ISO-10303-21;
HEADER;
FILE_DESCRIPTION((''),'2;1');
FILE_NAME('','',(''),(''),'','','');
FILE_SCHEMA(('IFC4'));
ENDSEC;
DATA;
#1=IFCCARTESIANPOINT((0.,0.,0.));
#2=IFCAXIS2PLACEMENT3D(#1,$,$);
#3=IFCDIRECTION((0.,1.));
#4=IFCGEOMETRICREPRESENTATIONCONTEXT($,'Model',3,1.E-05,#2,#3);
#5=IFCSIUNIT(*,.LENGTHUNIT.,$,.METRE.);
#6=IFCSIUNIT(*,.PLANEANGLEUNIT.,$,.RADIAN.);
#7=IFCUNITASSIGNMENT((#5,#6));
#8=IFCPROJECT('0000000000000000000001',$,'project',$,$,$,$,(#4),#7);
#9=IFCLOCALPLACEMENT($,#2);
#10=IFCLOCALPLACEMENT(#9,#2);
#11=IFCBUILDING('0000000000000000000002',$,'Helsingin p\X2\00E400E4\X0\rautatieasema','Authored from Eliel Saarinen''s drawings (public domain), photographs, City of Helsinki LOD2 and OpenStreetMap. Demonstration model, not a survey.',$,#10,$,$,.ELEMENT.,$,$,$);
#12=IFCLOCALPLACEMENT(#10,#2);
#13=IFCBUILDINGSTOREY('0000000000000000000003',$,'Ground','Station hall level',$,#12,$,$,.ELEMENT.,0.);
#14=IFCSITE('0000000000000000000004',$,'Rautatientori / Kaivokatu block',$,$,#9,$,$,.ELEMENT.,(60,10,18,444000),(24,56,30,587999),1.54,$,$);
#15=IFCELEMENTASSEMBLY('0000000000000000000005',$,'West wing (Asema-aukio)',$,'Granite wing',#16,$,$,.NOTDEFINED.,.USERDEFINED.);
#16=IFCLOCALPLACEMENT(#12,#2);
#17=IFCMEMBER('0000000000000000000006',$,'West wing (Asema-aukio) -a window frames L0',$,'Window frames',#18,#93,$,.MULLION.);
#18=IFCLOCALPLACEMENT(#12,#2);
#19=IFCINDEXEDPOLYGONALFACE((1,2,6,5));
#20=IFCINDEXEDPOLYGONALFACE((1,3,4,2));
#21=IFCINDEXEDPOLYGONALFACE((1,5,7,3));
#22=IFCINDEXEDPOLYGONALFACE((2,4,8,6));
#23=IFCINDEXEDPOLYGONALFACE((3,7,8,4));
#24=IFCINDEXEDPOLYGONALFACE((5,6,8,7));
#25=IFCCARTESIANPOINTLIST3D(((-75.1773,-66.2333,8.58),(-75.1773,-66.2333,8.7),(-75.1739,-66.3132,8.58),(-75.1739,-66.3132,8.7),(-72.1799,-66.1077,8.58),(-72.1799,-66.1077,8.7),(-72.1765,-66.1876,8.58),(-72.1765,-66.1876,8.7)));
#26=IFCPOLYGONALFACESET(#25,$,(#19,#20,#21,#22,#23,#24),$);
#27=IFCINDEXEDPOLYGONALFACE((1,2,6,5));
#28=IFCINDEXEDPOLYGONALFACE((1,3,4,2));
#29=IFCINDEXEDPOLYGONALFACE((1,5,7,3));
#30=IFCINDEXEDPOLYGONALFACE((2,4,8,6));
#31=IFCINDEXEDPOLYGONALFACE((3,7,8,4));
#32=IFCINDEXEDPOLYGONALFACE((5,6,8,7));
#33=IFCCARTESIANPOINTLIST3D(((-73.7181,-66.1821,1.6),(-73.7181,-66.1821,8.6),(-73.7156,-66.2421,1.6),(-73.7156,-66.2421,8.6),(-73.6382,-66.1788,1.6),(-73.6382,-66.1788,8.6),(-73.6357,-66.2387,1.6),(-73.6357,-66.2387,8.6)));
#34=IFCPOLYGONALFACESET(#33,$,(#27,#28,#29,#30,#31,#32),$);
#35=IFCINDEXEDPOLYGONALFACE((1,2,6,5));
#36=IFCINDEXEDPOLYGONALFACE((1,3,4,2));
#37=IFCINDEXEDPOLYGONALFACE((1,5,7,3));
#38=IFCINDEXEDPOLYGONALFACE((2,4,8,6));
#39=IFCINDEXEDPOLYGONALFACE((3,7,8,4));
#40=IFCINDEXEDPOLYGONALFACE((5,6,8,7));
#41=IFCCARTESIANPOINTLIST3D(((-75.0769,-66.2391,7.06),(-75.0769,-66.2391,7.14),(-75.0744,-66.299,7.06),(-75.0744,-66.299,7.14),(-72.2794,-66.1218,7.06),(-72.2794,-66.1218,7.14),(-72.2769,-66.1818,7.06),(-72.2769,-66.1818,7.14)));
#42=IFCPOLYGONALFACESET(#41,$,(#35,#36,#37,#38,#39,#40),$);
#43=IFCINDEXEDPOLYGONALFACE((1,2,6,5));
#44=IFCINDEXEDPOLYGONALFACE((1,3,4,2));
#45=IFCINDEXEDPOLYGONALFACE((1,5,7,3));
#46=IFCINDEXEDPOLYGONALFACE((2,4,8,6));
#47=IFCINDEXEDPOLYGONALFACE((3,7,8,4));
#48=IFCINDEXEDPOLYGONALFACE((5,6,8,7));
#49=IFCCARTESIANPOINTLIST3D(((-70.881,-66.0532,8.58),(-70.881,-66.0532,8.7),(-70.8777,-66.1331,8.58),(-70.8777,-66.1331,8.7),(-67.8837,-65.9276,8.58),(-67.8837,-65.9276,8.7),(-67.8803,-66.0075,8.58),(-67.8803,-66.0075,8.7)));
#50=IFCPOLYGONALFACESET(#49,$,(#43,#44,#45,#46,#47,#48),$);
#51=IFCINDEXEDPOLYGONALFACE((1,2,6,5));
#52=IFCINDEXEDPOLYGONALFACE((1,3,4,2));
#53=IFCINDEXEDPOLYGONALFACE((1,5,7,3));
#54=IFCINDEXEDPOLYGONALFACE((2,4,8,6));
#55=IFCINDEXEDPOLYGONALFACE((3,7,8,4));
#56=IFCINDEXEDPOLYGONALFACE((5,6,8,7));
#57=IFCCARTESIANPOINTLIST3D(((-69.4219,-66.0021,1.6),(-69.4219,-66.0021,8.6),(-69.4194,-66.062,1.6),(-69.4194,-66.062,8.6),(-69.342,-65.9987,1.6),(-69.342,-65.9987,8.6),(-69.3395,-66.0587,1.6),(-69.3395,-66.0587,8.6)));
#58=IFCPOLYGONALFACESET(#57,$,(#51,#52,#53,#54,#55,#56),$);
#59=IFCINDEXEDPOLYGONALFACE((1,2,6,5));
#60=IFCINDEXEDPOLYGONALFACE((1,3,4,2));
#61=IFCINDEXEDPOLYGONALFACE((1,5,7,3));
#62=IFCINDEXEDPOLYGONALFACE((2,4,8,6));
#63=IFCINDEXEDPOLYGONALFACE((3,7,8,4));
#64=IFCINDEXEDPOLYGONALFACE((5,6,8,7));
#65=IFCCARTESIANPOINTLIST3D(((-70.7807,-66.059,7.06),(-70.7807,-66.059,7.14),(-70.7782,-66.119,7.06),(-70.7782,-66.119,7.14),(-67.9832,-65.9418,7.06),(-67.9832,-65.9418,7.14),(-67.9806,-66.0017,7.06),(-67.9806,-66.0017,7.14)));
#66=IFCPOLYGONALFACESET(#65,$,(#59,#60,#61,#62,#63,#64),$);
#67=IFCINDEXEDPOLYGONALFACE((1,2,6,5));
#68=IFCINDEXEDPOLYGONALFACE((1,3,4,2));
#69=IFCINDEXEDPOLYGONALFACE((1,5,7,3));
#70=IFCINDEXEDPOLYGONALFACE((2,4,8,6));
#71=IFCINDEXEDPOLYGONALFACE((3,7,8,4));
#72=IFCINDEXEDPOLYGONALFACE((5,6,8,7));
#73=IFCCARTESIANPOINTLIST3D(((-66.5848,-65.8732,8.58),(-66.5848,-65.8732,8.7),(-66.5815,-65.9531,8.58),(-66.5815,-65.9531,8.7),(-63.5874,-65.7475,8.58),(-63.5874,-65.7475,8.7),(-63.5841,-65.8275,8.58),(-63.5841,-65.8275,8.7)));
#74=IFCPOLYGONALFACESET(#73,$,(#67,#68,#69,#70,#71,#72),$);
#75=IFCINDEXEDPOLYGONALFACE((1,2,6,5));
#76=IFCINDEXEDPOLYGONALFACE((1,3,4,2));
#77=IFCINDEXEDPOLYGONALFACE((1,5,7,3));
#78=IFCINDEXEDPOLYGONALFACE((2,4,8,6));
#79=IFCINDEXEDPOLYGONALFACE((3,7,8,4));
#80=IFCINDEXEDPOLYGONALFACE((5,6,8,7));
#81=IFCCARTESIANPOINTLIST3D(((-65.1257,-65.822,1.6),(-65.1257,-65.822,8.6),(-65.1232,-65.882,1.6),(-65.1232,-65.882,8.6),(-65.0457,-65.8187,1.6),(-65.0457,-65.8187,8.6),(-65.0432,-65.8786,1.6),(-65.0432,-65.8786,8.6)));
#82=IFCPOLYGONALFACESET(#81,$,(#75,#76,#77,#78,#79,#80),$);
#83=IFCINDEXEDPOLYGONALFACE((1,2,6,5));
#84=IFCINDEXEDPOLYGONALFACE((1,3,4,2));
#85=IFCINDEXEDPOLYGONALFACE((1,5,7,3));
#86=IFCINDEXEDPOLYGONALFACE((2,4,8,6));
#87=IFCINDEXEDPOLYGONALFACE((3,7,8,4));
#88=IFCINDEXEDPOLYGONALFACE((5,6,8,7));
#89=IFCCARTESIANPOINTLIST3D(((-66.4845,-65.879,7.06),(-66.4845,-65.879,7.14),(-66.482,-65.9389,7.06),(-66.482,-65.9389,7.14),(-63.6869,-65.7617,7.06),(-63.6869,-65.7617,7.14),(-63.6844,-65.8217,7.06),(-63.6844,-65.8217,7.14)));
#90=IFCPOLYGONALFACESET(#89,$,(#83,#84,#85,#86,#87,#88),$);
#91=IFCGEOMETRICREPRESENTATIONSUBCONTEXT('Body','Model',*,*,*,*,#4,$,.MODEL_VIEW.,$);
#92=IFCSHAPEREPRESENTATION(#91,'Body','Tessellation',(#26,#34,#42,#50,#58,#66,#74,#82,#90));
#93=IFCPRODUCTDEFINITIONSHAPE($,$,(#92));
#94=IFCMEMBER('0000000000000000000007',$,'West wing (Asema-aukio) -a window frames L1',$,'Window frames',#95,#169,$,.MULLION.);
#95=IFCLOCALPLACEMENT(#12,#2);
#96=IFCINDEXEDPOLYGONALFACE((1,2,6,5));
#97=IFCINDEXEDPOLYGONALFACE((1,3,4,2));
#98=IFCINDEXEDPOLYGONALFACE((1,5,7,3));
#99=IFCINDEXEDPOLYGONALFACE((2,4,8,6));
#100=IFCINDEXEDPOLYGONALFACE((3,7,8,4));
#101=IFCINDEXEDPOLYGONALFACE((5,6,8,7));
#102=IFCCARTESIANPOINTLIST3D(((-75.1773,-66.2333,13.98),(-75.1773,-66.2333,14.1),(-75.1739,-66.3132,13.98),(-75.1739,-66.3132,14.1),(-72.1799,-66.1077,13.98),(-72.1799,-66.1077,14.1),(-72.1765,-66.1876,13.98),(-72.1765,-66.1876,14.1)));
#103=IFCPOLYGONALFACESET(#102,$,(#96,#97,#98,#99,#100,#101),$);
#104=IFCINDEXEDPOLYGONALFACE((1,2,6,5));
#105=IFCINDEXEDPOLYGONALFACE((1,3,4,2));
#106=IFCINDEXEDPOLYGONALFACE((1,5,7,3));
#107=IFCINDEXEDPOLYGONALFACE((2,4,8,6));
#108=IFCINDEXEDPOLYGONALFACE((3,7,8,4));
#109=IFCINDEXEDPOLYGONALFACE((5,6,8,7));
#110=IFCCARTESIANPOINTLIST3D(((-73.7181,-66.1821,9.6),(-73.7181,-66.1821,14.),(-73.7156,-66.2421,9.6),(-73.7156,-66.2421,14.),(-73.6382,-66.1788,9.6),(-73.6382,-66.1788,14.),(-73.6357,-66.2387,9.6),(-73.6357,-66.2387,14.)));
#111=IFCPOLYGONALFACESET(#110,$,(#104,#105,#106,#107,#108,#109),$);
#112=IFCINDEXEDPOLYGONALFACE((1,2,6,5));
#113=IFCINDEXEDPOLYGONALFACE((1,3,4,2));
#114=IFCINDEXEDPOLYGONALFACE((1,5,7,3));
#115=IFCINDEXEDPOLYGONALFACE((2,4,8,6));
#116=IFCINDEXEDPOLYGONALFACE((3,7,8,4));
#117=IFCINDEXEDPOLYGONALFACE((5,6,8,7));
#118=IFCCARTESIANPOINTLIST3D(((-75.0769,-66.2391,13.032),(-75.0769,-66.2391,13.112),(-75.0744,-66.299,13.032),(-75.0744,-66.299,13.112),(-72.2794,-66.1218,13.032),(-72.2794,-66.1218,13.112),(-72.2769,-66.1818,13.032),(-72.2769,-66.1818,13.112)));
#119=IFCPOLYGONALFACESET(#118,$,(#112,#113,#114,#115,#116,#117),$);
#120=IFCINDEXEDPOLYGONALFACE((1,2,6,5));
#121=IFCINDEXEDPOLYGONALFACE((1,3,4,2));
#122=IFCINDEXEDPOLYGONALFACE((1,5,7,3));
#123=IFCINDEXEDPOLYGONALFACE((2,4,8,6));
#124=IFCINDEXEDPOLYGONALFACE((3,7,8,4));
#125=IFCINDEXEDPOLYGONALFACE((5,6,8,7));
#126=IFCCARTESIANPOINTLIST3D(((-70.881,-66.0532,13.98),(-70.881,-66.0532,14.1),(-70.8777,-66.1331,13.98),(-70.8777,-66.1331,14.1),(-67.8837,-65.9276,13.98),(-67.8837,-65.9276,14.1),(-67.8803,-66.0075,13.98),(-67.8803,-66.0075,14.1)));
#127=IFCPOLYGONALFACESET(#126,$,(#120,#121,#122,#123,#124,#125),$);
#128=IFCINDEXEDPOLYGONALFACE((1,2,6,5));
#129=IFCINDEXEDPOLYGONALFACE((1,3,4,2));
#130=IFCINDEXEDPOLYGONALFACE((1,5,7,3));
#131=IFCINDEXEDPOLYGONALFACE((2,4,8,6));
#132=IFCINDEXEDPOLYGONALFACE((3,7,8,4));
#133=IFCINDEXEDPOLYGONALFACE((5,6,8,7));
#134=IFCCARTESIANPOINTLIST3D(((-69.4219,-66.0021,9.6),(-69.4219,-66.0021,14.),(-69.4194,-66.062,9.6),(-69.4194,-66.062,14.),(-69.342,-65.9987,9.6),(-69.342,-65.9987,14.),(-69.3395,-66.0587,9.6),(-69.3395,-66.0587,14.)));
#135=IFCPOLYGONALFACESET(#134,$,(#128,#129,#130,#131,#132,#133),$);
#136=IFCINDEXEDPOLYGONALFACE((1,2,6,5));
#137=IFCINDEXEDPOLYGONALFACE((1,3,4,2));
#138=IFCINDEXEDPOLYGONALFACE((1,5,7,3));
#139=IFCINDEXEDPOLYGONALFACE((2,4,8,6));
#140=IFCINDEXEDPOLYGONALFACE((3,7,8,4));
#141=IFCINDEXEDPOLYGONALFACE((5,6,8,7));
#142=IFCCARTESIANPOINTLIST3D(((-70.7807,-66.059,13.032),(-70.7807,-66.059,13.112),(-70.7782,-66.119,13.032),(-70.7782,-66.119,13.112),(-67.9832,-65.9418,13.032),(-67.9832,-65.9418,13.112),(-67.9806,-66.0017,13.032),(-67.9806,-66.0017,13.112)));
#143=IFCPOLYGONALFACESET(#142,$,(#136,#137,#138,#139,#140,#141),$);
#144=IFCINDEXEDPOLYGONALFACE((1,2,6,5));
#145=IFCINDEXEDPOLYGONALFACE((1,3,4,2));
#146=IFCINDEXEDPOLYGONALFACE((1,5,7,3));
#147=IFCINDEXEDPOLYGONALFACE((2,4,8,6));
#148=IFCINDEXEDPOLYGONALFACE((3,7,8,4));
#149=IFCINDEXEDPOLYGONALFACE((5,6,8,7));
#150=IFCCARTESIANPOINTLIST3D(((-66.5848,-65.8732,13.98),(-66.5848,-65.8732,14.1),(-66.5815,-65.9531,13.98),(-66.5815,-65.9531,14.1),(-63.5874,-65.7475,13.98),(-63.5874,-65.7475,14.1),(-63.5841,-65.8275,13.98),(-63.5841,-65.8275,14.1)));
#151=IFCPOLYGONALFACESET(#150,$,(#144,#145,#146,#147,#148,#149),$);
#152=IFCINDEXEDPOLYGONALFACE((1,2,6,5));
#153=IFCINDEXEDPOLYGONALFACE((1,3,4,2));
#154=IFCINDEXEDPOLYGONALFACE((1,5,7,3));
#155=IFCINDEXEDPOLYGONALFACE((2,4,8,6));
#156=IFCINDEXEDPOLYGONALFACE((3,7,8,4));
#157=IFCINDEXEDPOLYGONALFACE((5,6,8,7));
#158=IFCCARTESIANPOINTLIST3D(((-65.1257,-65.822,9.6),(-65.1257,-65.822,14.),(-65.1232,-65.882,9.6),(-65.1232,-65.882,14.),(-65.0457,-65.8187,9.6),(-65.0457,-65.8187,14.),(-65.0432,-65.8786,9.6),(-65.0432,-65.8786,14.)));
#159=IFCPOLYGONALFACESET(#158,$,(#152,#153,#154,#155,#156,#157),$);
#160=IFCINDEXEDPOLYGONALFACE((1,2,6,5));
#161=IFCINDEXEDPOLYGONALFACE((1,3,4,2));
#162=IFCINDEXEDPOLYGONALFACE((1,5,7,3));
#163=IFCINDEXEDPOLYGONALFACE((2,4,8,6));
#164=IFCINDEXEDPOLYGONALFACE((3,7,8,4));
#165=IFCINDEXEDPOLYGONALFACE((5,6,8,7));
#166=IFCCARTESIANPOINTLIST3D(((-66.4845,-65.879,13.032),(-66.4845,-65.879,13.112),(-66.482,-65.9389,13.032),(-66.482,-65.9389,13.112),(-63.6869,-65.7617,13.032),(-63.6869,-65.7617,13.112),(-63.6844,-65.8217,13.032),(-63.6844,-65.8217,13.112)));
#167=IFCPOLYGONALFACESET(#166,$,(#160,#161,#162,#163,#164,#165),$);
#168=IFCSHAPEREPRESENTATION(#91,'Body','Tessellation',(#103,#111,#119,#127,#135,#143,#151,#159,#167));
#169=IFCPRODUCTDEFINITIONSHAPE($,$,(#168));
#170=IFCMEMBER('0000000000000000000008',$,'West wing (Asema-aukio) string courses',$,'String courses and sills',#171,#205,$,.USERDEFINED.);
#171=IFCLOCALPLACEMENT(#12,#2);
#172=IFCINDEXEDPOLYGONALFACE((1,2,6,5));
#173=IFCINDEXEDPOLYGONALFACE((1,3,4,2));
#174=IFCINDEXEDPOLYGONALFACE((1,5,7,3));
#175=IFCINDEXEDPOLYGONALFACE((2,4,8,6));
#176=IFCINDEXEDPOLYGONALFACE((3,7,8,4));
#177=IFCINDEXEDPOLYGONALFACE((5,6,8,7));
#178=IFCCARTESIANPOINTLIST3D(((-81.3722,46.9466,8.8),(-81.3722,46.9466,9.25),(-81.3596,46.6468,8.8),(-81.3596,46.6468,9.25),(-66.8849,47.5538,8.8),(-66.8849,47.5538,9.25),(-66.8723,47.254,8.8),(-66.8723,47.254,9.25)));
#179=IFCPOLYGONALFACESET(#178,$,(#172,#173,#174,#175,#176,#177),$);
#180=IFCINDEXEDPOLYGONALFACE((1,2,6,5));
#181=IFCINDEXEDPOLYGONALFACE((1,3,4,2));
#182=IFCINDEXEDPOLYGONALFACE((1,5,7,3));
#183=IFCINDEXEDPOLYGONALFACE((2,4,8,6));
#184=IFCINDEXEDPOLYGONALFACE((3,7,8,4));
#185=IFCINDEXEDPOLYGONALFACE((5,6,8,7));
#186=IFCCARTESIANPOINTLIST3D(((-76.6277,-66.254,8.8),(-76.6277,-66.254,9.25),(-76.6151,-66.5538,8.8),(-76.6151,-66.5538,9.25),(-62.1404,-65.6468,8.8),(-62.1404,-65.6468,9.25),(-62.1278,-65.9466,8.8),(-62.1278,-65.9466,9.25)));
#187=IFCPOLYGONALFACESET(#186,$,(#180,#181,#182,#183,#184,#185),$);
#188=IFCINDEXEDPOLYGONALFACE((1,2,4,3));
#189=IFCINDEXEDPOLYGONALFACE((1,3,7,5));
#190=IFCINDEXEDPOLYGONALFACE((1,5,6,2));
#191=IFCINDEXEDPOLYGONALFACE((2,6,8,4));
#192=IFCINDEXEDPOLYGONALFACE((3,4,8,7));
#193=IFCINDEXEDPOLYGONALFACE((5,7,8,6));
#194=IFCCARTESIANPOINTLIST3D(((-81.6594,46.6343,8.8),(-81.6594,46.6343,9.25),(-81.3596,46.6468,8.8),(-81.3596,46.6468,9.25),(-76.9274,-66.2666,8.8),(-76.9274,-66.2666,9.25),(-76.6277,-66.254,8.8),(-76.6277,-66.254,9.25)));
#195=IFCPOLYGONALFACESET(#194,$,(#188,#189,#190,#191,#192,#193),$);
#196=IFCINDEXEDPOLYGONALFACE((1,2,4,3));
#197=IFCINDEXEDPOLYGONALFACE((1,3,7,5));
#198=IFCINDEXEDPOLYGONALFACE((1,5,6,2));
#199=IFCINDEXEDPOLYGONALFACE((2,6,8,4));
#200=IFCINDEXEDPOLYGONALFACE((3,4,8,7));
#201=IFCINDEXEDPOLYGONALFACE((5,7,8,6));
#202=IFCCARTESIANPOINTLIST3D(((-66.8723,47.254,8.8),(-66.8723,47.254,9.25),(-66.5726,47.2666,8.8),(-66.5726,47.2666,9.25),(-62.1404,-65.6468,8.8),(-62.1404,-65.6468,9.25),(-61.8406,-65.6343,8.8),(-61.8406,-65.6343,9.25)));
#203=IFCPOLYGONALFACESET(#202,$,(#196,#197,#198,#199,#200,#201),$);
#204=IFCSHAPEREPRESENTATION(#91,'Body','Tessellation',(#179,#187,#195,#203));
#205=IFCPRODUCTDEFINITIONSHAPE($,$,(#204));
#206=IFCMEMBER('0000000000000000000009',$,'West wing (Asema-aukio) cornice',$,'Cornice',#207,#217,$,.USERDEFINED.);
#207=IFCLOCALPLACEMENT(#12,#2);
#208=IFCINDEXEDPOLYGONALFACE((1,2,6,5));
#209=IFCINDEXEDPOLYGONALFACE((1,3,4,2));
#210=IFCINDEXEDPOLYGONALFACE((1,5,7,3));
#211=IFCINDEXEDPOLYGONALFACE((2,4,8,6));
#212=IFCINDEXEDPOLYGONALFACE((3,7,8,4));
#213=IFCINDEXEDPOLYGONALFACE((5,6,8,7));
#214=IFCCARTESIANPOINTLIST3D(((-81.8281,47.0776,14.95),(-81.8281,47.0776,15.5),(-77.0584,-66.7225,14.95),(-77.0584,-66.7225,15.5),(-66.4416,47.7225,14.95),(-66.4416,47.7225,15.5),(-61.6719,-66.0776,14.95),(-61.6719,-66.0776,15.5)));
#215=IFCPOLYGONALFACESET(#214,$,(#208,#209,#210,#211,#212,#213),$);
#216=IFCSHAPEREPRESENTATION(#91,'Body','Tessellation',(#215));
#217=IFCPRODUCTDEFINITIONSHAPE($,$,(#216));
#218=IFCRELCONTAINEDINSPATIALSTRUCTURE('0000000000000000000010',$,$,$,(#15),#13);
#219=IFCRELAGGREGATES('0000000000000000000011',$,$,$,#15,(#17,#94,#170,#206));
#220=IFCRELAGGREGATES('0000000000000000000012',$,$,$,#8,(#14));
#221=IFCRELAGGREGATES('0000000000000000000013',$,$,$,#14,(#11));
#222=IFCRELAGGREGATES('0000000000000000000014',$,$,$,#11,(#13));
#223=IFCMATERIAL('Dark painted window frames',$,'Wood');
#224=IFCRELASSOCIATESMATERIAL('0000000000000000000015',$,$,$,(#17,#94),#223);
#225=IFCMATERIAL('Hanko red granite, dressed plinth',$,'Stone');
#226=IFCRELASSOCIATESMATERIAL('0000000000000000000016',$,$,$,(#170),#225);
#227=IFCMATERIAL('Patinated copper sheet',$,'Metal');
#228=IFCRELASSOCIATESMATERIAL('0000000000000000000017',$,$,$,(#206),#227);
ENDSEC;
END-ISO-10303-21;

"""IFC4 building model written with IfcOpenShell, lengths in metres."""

from ifc_helpers import new_model, si_unit, direction, frame, frame_2d, origin, place, context, subcontext, project, spatial, rectangle, extrude, material, element, aggregate, save


model = new_model("IFC4")

# Units and contexts
model_context = context("Model", 3, precision=1e-05, world=origin(), true_north=direction((0.0, 1.0)))
body_context = subcontext(model_context, "Body", "Model", "MODEL_VIEW")
ifc_project = project(units=[si_unit("LENGTHUNIT", "METRE"), si_unit("PLANEANGLEUNIT", "RADIAN")], contexts=[model_context])

# Site, building, storey
site_placement = place(None, origin())
site = spatial("IfcSite", under=ifc_project, at=site_placement, Name="Rautatientori / Kaivokatu block", CompositionType="ELEMENT", RefLatitude=(60, 10, 18, 444000), RefLongitude=(24, 56, 30, 587999), RefElevation=1.54)
building_placement = place(site_placement, origin())
building = spatial("IfcBuilding", under=site, at=building_placement, Name="Helsingin päärautatieasema", Description="Authored from Eliel Saarinen's drawings (public domain), photographs, City of Helsinki LOD2 and OpenStreetMap. Demonstration model, not a survey.", CompositionType="ELEMENT")
storey_placement = place(building_placement, origin())
storey = spatial("IfcBuildingStorey", under=building, at=storey_placement, Name="Ground", Description="Station hall level", CompositionType="ELEMENT", Elevation=0.0)

# Element assembly, members
assembly_placement = place(building_placement, origin())
assembly = element("IfcElementAssembly", 1, at=assembly_placement, inside=storey, Name="West wing (Asema-aukio)", ObjectType="Granite wing", AssemblyPlace="NOTDEFINED", PredefinedType="USERDEFINED")
ifc_material_1 = material(Name="Dark painted window frames", Category="Wood")
member_1_placement = place(building_placement, origin())
member_1 = element("IfcMember", 2, at=member_1_placement, material=ifc_material_1, Name="West wing (Asema-aukio) -a window frames L0", ObjectType="Window frames", PredefinedType="MULLION", context=body_context, shape_type="SweptSolid", body=[
    extrude(rectangle(XDim=3.0, YDim=0.08, at=frame_2d((0.0, 0.0), x_axis=(0.999123, 0.041876))), frame((-73.6769, -66.2104, 8.58)), (0.0, 0.0, 1.0), 0.12),
    extrude(rectangle(XDim=0.08, YDim=0.06, at=frame_2d((0.0, 0.0), x_axis=(0.999123, 0.041876))), frame((-73.6769, -66.2104, 1.6)), (0.0, 0.0, 1.0), 7.0),
    extrude(rectangle(XDim=2.8, YDim=0.06, at=frame_2d((0.0, 0.0), x_axis=(0.999123, 0.041876))), frame((-73.6769, -66.2104, 7.06)), (0.0, 0.0, 1.0), 0.08),
    extrude(rectangle(XDim=3.0, YDim=0.08, at=frame_2d((0.0, 0.0), x_axis=(0.999123, 0.041876))), frame((-69.3807, -66.0304, 8.58)), (0.0, 0.0, 1.0), 0.12),
    extrude(rectangle(XDim=0.08, YDim=0.06, at=frame_2d((0.0, 0.0), x_axis=(0.999123, 0.041876))), frame((-69.3807, -66.0304, 1.6)), (0.0, 0.0, 1.0), 7.0),
    extrude(rectangle(XDim=2.8, YDim=0.06, at=frame_2d((0.0, 0.0), x_axis=(0.999123, 0.041876))), frame((-69.3807, -66.0304, 7.06)), (0.0, 0.0, 1.0), 0.08),
    extrude(rectangle(XDim=3.0, YDim=0.08, at=frame_2d((0.0, 0.0), x_axis=(0.999123, 0.041876))), frame((-65.0844, -65.8503, 8.58)), (0.0, 0.0, 1.0), 0.12),
    extrude(rectangle(XDim=0.08, YDim=0.06, at=frame_2d((0.0, 0.0), x_axis=(0.999123, 0.041876))), frame((-65.0844, -65.8503, 1.6)), (0.0, 0.0, 1.0), 7.0),
    extrude(rectangle(XDim=2.8, YDim=0.06, at=frame_2d((0.0, 0.0), x_axis=(0.999123, 0.041876))), frame((-65.0844, -65.8503, 7.06)), (0.0, 0.0, 1.0), 0.08),
])
member_2_placement = place(building_placement, origin())
member_2 = element("IfcMember", 3, at=member_2_placement, material=ifc_material_1, Name="West wing (Asema-aukio) -a window frames L1", ObjectType="Window frames", PredefinedType="MULLION", context=body_context, shape_type="SweptSolid", body=[
    extrude(rectangle(XDim=3.0, YDim=0.08, at=frame_2d((0.0, 0.0), x_axis=(0.999123, 0.041876))), frame((-73.6769, -66.2104, 13.98)), (0.0, 0.0, 1.0), 0.12),
    extrude(rectangle(XDim=0.08, YDim=0.06, at=frame_2d((0.0, 0.0), x_axis=(0.999123, 0.041876))), frame((-73.6769, -66.2104, 9.6)), (0.0, 0.0, 1.0), 4.4),
    extrude(rectangle(XDim=2.8, YDim=0.06, at=frame_2d((0.0, 0.0), x_axis=(0.999123, 0.041876))), frame((-73.6769, -66.2104, 13.032)), (0.0, 0.0, 1.0), 0.08),
    extrude(rectangle(XDim=3.0, YDim=0.08, at=frame_2d((0.0, 0.0), x_axis=(0.999123, 0.041876))), frame((-69.3807, -66.0304, 13.98)), (0.0, 0.0, 1.0), 0.12),
    extrude(rectangle(XDim=0.08, YDim=0.06, at=frame_2d((0.0, 0.0), x_axis=(0.999123, 0.041876))), frame((-69.3807, -66.0304, 9.6)), (0.0, 0.0, 1.0), 4.4),
    extrude(rectangle(XDim=2.8, YDim=0.06, at=frame_2d((0.0, 0.0), x_axis=(0.999123, 0.041876))), frame((-69.3807, -66.0304, 13.032)), (0.0, 0.0, 1.0), 0.08),
    extrude(rectangle(XDim=3.0, YDim=0.08, at=frame_2d((0.0, 0.0), x_axis=(0.999123, 0.041876))), frame((-65.0844, -65.8503, 13.98)), (0.0, 0.0, 1.0), 0.12),
    extrude(rectangle(XDim=0.08, YDim=0.06, at=frame_2d((0.0, 0.0), x_axis=(0.999123, 0.041876))), frame((-65.0844, -65.8503, 9.6)), (0.0, 0.0, 1.0), 4.4),
    extrude(rectangle(XDim=2.8, YDim=0.06, at=frame_2d((0.0, 0.0), x_axis=(0.999123, 0.041876))), frame((-65.0844, -65.8503, 13.032)), (0.0, 0.0, 1.0), 0.08),
])
ifc_material_2 = material(Name="Hanko red granite, dressed plinth", Category="Stone")
member_3_placement = place(building_placement, origin())
member_3 = element("IfcMember", 4, at=member_3_placement, material=ifc_material_2, Name="West wing (Asema-aukio) string courses", ObjectType="String courses and sills", PredefinedType="USERDEFINED", context=body_context, shape_type="SweptSolid", body=[
    extrude(rectangle(XDim=14.5, YDim=0.3, at=frame_2d((0.0, 0.0), x_axis=(-0.999123, -0.041876))), frame((-74.1223, 47.1003, 8.8)), (0.0, 0.0, 1.0), 0.45),
    extrude(rectangle(XDim=14.5, YDim=0.3, at=frame_2d((0.0, 0.0), x_axis=(0.999123, 0.041876))), frame((-69.3777, -66.1003, 8.8)), (0.0, 0.0, 1.0), 0.45),
    extrude(rectangle(XDim=113.0, YDim=0.3, at=frame_2d((0.0, 0.0), x_axis=(0.041876, -0.999123))), frame((-79.1435, -9.8099, 8.8)), (0.0, 0.0, 1.0), 0.45),
    extrude(rectangle(XDim=113.0, YDim=0.3, at=frame_2d((0.0, 0.0), x_axis=(-0.041876, 0.999123))), frame((-64.3565, -9.1901, 8.8)), (0.0, 0.0, 1.0), 0.45),
])
ifc_material_3 = material(Name="Patinated copper sheet", Category="Metal")
member_4_placement = place(building_placement, origin())
member_4 = element("IfcMember", 5, at=member_4_placement, material=ifc_material_3, Name="West wing (Asema-aukio) cornice", ObjectType="Cornice", PredefinedType="USERDEFINED", context=body_context, shape_type="SweptSolid", body=[
    extrude(rectangle(XDim=113.9, YDim=15.4, at=frame_2d((0.0, 0.0), x_axis=(-0.041876, 0.999123))), frame((-71.75, -9.5, 14.95)), (0.0, 0.0, 1.0), 0.55),
])
aggregate(assembly, [member_1, member_2, member_3, member_4])

save(model, "model.ifc")
